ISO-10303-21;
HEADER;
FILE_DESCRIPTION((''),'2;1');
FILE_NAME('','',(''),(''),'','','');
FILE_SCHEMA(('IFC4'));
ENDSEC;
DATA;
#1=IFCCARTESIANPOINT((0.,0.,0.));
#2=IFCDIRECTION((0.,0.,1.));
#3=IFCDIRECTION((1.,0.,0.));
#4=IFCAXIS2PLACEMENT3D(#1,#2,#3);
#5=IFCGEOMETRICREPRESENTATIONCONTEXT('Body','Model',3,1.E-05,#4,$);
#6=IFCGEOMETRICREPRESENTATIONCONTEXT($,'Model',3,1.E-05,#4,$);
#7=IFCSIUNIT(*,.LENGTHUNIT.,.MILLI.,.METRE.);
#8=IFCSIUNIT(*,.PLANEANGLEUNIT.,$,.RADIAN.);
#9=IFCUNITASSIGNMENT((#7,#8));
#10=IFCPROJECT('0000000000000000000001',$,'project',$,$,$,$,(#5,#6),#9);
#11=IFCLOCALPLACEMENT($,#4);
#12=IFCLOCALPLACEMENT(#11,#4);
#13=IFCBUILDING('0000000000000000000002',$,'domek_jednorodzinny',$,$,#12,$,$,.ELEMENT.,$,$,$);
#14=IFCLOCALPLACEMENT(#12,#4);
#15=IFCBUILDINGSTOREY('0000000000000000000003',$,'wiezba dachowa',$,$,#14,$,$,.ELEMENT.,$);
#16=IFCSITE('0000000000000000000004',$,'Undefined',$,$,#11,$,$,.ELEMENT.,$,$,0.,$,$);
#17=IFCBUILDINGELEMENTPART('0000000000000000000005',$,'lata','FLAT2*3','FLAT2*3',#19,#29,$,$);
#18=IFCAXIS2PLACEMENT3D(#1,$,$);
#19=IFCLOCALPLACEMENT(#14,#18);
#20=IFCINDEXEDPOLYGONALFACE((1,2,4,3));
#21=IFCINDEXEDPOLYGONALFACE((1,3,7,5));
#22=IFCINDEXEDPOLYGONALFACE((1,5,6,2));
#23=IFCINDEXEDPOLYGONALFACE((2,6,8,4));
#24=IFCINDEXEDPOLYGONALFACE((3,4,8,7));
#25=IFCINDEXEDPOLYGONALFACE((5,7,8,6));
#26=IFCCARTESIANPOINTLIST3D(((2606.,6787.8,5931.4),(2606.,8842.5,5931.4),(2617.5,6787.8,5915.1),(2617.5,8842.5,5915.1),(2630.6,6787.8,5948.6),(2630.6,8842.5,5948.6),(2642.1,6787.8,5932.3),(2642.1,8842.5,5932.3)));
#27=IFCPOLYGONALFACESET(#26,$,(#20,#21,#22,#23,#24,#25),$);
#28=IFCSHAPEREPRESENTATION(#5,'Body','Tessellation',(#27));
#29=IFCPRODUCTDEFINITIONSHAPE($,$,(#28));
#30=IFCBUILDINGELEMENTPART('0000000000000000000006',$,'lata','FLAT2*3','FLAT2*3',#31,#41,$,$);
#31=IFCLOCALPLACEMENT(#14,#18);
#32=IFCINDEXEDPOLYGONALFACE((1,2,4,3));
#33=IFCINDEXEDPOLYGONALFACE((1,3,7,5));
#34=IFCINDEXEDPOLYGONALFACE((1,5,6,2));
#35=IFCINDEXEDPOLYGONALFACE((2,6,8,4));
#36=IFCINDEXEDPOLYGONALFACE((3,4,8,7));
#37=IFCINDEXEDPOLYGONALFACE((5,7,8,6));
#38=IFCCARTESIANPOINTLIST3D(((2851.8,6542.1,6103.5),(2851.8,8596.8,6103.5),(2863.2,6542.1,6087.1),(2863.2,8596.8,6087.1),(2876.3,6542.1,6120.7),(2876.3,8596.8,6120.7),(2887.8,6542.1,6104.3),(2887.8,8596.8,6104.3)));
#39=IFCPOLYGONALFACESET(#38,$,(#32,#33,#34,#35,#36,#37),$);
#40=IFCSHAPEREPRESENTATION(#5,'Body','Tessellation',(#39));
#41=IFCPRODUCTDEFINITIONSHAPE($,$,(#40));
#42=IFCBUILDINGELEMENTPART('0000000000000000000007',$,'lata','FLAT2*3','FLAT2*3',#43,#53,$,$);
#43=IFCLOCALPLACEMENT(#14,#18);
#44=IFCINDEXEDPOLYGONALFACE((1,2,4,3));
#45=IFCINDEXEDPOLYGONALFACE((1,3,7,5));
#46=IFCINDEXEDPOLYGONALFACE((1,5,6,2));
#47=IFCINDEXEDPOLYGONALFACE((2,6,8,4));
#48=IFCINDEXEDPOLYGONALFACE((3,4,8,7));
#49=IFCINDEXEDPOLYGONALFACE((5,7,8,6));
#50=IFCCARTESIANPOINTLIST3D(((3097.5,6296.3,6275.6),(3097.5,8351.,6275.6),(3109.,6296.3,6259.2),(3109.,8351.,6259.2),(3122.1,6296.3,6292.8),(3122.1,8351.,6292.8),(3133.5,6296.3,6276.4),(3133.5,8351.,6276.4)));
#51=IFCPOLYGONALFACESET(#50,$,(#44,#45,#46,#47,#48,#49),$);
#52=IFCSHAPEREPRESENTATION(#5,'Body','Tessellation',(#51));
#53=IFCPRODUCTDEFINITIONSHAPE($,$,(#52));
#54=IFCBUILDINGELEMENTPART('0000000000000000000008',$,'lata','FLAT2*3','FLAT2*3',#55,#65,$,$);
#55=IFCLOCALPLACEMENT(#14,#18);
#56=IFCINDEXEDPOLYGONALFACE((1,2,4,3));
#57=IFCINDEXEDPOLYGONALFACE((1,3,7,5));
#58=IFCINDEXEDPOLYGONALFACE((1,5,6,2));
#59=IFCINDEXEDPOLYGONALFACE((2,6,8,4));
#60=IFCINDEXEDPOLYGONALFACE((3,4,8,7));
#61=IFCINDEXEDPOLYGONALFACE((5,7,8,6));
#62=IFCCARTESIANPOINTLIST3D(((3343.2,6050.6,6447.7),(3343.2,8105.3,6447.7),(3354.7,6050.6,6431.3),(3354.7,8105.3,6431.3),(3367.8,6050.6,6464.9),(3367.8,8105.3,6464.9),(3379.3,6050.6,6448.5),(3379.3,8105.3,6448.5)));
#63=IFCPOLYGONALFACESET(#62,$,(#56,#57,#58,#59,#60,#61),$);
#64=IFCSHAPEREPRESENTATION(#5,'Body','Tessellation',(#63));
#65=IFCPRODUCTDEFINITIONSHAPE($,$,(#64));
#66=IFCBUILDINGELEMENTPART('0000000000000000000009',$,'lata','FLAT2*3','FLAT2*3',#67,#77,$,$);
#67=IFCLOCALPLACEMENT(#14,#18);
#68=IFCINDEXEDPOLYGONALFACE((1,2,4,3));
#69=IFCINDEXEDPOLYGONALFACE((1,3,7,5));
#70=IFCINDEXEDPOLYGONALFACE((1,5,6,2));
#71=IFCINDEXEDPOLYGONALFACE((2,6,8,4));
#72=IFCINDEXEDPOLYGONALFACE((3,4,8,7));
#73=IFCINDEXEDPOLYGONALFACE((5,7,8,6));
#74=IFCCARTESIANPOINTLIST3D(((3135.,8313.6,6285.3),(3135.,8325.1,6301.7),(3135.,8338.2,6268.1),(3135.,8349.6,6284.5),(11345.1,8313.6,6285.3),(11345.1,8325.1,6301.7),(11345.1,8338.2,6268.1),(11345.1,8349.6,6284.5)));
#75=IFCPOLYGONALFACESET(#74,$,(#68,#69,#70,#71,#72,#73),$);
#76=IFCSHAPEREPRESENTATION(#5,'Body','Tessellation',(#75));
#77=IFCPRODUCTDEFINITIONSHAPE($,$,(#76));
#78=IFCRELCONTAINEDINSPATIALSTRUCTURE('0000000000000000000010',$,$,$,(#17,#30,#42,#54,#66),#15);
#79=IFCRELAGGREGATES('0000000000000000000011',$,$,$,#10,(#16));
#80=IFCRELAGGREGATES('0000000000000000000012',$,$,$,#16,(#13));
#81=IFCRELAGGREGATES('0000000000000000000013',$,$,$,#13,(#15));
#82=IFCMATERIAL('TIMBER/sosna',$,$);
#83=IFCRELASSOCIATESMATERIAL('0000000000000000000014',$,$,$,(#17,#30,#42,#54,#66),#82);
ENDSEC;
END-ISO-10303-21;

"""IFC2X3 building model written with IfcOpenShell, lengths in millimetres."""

from ifc_helpers import new_model, si_unit, frame, origin_with_axes, origin_2d_with_axis, place, context, project, spatial, rectangle, extrude, material, element, save


model = new_model("IFC2X3")

# Units and contexts
model_context_1 = context("Model", 3, precision=1e-05, world=origin_with_axes(), identifier="Body")
model_context_2 = context("Model", 3, precision=1e-05, world=origin_with_axes())
ifc_project = project(units=[si_unit("LENGTHUNIT", "METRE", prefix="MILLI"), si_unit("PLANEANGLEUNIT", "RADIAN")], contexts=[model_context_1, model_context_2])

# Site, building, storey
site_placement = place(None, origin_with_axes())
site = spatial("IfcSite", under=ifc_project, at=site_placement, Name="Undefined", CompositionType="ELEMENT", RefElevation=0.0)
building_placement = place(site_placement, origin_with_axes())
building = spatial("IfcBuilding", under=site, at=building_placement, Name="domek_jednorodzinny", CompositionType="ELEMENT")
storey_placement = place(building_placement, origin_with_axes())
storey = spatial("IfcBuildingStorey", under=building, at=storey_placement, Name="wiezba dachowa", CompositionType="ELEMENT")

# Building element parts
ifc_material = material(Name="TIMBER/sosna")
building_element_part_1_placement = place(storey_placement, frame((2624.0, 8842.5, 5931.9), z_axis=(0.819152, 0.0, 0.573576), x_axis=(0.0, -1.0, 0.0)))
element("IfcBuildingElementPart", 1, at=building_element_part_1_placement, inside=storey, material=ifc_material, Name="lata", Description="FLAT2*3", ObjectType="FLAT2*3", context=model_context_1, shape_type="SweptSolid", body=[
    extrude(rectangle(XDim=20.0, YDim=30.0, at=origin_2d_with_axis()), frame((2054.7, 0.0, 0.0), z_axis=(-1.0, 0.0, 0.0), x_axis=(0.0, -1.0, 0.0)), (0.0, 0.0, 1.0), 2054.7),
])
building_element_part_2_placement = place(storey_placement, frame((2869.8, 8596.8, 6103.9), z_axis=(0.819152, 0.0, 0.573576), x_axis=(0.0, -1.0, 0.0)))
element("IfcBuildingElementPart", 2, at=building_element_part_2_placement, inside=storey, material=ifc_material, Name="lata", Description="FLAT2*3", ObjectType="FLAT2*3", context=model_context_1, shape_type="SweptSolid", body=[
    extrude(rectangle(XDim=20.0, YDim=30.0, at=origin_2d_with_axis()), frame((2054.7, 0.0, 0.0), z_axis=(-1.0, 0.0, 0.0), x_axis=(0.0, -1.0, 0.0)), (0.0, 0.0, 1.0), 2054.7),
])
building_element_part_3_placement = place(storey_placement, frame((3115.5, 8351.0, 6276.0), z_axis=(0.819152, 0.0, 0.573576), x_axis=(0.0, -1.0, 0.0)))
element("IfcBuildingElementPart", 3, at=building_element_part_3_placement, inside=storey, material=ifc_material, Name="lata", Description="FLAT2*3", ObjectType="FLAT2*3", context=model_context_1, shape_type="SweptSolid", body=[
    extrude(rectangle(XDim=20.0, YDim=30.0, at=origin_2d_with_axis()), frame((2054.7, 0.0, 0.0), z_axis=(-1.0, 0.0, 0.0), x_axis=(0.0, -1.0, 0.0)), (0.0, 0.0, 1.0), 2054.7),
])
building_element_part_4_placement = place(storey_placement, frame((3361.3, 8105.3, 6448.1), z_axis=(0.819152, 0.0, 0.573576), x_axis=(0.0, -1.0, 0.0)))
element("IfcBuildingElementPart", 4, at=building_element_part_4_placement, inside=storey, material=ifc_material, Name="lata", Description="FLAT2*3", ObjectType="FLAT2*3", context=model_context_1, shape_type="SweptSolid", body=[
    extrude(rectangle(XDim=20.0, YDim=30.0, at=origin_2d_with_axis()), frame((2054.7, 0.0, 0.0), z_axis=(-1.0, 0.0, 0.0), x_axis=(0.0, -1.0, 0.0)), (0.0, 0.0, 1.0), 2054.7),
])
building_element_part_5_placement = place(storey_placement, frame((3135.0, 8331.6, 6284.9), z_axis=(0.0, -0.819154, 0.573574), x_axis=(1.0, 0.0, 0.0)))
element("IfcBuildingElementPart", 5, at=building_element_part_5_placement, inside=storey, material=ifc_material, Name="lata", Description="FLAT2*3", ObjectType="FLAT2*3", context=model_context_1, shape_type="SweptSolid", body=[
    extrude(rectangle(XDim=20.0, YDim=30.0, at=origin_2d_with_axis()), frame((8210.1, 0.0, 0.0), z_axis=(-1.0, 0.0, 0.0), x_axis=(0.0, -1.0, 0.0)), (0.0, 0.0, 1.0), 8210.1),
])

save(model, "model.ifc")
